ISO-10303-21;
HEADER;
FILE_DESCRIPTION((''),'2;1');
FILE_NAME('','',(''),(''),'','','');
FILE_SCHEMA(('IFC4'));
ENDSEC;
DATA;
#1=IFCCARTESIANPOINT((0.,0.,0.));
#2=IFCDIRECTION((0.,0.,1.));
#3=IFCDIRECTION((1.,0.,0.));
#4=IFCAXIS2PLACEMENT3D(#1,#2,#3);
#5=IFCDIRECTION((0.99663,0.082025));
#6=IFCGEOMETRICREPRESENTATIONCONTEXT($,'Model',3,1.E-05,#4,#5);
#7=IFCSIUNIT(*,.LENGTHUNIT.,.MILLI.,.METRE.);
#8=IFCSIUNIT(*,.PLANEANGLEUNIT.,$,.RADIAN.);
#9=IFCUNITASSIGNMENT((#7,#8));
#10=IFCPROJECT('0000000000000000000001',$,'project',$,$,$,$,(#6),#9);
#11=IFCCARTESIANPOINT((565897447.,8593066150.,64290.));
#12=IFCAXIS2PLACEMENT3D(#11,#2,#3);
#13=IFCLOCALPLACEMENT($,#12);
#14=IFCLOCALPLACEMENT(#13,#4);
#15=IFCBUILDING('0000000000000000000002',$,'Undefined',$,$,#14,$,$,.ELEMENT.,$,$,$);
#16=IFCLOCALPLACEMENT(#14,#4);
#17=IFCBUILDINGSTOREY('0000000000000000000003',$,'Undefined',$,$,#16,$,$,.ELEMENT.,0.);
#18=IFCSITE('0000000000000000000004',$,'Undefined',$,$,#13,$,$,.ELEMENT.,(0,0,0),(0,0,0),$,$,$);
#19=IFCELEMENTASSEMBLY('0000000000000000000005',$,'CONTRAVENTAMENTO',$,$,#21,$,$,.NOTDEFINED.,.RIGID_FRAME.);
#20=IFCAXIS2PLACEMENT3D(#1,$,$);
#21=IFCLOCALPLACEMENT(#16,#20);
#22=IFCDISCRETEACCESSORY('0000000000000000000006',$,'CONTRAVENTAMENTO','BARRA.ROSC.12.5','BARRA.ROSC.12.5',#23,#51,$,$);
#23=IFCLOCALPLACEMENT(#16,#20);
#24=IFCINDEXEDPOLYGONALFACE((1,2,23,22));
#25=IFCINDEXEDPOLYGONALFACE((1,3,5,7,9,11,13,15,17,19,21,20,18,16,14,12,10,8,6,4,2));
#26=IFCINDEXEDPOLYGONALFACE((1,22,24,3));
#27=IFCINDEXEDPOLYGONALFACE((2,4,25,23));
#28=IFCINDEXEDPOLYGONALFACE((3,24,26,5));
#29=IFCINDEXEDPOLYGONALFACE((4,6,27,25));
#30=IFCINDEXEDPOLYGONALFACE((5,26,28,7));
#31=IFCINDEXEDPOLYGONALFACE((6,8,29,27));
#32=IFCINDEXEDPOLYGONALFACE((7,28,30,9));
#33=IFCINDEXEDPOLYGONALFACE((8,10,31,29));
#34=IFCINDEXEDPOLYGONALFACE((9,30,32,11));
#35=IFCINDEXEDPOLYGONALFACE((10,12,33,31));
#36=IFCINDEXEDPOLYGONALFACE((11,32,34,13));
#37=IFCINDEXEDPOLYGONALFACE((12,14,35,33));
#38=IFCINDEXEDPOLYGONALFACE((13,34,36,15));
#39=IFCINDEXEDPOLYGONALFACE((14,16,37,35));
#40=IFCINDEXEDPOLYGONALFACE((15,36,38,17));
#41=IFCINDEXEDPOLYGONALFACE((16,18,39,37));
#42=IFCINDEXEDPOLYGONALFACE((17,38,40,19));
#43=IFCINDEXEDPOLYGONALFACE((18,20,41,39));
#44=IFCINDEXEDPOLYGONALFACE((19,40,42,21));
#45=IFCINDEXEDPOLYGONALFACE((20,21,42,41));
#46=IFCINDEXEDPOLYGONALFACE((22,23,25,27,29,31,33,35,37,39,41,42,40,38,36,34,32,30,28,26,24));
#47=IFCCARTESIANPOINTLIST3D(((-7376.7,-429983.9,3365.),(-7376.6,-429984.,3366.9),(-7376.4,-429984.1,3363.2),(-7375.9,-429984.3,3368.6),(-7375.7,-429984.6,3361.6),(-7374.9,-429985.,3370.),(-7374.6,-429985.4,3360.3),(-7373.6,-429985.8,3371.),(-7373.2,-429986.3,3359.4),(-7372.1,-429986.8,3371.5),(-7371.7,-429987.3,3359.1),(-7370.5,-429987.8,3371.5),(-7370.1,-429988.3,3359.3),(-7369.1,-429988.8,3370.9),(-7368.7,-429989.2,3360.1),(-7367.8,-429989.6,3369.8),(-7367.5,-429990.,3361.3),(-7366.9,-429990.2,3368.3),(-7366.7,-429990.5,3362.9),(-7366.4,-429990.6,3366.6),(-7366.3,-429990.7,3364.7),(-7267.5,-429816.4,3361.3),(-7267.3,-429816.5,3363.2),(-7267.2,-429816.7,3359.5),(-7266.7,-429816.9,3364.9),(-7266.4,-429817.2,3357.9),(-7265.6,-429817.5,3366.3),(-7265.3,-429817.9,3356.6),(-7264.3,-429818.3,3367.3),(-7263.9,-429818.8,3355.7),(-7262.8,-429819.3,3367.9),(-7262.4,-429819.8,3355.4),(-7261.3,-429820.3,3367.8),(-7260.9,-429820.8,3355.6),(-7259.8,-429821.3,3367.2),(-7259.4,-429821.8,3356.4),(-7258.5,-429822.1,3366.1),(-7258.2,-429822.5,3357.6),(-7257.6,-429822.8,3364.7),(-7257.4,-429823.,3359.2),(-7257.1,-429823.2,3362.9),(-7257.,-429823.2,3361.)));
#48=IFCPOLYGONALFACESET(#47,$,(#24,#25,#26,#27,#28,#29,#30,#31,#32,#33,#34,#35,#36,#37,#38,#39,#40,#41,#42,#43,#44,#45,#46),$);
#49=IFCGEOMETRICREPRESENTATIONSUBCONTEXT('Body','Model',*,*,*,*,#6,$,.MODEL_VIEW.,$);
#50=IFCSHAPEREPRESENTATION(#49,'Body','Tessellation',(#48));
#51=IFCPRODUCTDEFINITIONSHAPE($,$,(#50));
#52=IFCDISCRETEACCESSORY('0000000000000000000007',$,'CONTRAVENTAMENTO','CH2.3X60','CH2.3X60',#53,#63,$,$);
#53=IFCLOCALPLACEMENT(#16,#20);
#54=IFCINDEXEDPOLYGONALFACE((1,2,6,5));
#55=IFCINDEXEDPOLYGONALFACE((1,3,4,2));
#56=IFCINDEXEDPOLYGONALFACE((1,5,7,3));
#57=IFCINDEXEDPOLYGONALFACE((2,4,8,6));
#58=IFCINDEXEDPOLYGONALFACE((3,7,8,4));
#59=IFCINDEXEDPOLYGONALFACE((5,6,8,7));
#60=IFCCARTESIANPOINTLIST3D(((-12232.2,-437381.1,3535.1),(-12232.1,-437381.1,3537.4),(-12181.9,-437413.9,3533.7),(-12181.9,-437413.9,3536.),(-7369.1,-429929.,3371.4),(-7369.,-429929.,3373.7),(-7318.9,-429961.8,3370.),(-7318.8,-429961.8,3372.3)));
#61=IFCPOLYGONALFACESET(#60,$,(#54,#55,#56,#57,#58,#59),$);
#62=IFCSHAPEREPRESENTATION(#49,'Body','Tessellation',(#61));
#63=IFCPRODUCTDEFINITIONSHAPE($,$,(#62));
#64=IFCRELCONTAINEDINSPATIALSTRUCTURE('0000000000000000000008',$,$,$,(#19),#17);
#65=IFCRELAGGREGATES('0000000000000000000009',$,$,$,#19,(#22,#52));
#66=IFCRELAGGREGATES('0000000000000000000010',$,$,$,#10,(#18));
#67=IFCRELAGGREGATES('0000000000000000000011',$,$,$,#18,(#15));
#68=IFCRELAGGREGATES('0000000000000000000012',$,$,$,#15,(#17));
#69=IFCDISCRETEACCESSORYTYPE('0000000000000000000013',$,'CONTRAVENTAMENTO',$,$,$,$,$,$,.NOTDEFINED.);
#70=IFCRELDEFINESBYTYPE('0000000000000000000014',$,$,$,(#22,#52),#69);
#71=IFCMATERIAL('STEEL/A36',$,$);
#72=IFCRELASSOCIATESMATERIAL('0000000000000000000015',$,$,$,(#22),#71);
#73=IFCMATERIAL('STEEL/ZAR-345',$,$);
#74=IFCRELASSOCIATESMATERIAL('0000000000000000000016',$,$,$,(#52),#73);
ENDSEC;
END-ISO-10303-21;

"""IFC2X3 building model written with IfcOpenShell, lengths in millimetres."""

from ifc_helpers import new_model, si_unit, direction, frame, origin_with_axes, origin_2d_with_axis, place, context, subcontext, project, spatial, polyline, circle, outline, extrude, material, type_object, element, aggregate, save


model = new_model("IFC2X3")

# Units and contexts
model_context = context("Model", 3, precision=1e-05, world=origin_with_axes(), true_north=direction((0.99663, 0.082025)))
body_context = subcontext(model_context, "Body", "Model", "MODEL_VIEW")
ifc_project = project(units=[si_unit("LENGTHUNIT", "METRE", prefix="MILLI"), si_unit("PLANEANGLEUNIT", "RADIAN")], contexts=[model_context])

# Site, building, storey
site_placement = place(None, frame((565897447.0, 8593066150.0, 64290.0), z_axis=(0.0, 0.0, 1.0), x_axis=(1.0, 0.0, 0.0)))
site = spatial("IfcSite", under=ifc_project, at=site_placement, Name="Undefined", CompositionType="ELEMENT", RefLatitude=(0, 0, 0), RefLongitude=(0, 0, 0))
building_placement = place(site_placement, origin_with_axes())
building = spatial("IfcBuilding", under=site, at=building_placement, Name="Undefined", CompositionType="ELEMENT")
storey_placement = place(building_placement, origin_with_axes())
storey = spatial("IfcBuildingStorey", under=building, at=storey_placement, Name="Undefined", CompositionType="ELEMENT", Elevation=0.0)

# Shared definitions
ifc_material_1 = material(Name="STEEL/A36")

# Element assembly, discrete accessories
assembly_1_placement = place(storey_placement, origin_with_axes())
assembly_1 = element("IfcElementAssembly", 1, at=assembly_1_placement, inside=storey, Name="CONTRAVENTAMENTO", AssemblyPlace="NOTDEFINED", PredefinedType="RIGID_FRAME")
discrete_accessory_type_1 = type_object("IfcDiscreteAccessoryType", Name="CONTRAVENTAMENTO")
discrete_accessory_1_placement = place(assembly_1_placement, frame((-7262.2, -429819.8, 3361.7), z_axis=(-0.836984, 0.546715, 0.02368), x_axis=(-0.546411, -0.837315, 0.018398)))
discrete_accessory_1 = element("IfcDiscreteAccessory", 2, at=discrete_accessory_1_placement, type_object=discrete_accessory_type_1, material=ifc_material_1, Name="CONTRAVENTAMENTO", Description="BARRA.ROSC.12.5", ObjectType="BARRA.ROSC.12.5", context=body_context, shape_type="SweptSolid", body=[
    extrude(circle(Radius=6.2, at=origin_2d_with_axis()), frame((200.0, 0.0, 0.0), z_axis=(-1.0, 0.0, 0.0), x_axis=(0.0, -1.0, 0.0)), (0.0, 0.0, 1.0), 200.0),
])
ifc_material_2 = material(Name="STEEL/ZAR-345")
discrete_accessory_2_placement = place(assembly_1_placement, frame((-7344.0, -429945.4, 3371.8), z_axis=(-0.029885, -0.00246, -0.99955), x_axis=(-0.546411, -0.837315, 0.018398)))
discrete_accessory_2 = element("IfcDiscreteAccessory", 3, at=discrete_accessory_2_placement, type_object=discrete_accessory_type_1, material=ifc_material_2, Name="CONTRAVENTAMENTO", Description="CH2.3X60", ObjectType="CH2.3X60", context=body_context, shape_type="SweptSolid", body=[
    extrude(outline(polyline([(0.0, 30.0), (8900.0, 30.0), (8900.0, -30.0), (0.0, -30.0), (0.0, 30.0)])), frame((0.0, 0.0, -1.1), z_axis=(0.0, 0.0, 1.0), x_axis=(1.0, 0.0, 0.0)), (0.0, 0.0, 1.0), 2.3),
])
aggregate(assembly_1, [discrete_accessory_1, discrete_accessory_2])

save(model, "model.ifc")
